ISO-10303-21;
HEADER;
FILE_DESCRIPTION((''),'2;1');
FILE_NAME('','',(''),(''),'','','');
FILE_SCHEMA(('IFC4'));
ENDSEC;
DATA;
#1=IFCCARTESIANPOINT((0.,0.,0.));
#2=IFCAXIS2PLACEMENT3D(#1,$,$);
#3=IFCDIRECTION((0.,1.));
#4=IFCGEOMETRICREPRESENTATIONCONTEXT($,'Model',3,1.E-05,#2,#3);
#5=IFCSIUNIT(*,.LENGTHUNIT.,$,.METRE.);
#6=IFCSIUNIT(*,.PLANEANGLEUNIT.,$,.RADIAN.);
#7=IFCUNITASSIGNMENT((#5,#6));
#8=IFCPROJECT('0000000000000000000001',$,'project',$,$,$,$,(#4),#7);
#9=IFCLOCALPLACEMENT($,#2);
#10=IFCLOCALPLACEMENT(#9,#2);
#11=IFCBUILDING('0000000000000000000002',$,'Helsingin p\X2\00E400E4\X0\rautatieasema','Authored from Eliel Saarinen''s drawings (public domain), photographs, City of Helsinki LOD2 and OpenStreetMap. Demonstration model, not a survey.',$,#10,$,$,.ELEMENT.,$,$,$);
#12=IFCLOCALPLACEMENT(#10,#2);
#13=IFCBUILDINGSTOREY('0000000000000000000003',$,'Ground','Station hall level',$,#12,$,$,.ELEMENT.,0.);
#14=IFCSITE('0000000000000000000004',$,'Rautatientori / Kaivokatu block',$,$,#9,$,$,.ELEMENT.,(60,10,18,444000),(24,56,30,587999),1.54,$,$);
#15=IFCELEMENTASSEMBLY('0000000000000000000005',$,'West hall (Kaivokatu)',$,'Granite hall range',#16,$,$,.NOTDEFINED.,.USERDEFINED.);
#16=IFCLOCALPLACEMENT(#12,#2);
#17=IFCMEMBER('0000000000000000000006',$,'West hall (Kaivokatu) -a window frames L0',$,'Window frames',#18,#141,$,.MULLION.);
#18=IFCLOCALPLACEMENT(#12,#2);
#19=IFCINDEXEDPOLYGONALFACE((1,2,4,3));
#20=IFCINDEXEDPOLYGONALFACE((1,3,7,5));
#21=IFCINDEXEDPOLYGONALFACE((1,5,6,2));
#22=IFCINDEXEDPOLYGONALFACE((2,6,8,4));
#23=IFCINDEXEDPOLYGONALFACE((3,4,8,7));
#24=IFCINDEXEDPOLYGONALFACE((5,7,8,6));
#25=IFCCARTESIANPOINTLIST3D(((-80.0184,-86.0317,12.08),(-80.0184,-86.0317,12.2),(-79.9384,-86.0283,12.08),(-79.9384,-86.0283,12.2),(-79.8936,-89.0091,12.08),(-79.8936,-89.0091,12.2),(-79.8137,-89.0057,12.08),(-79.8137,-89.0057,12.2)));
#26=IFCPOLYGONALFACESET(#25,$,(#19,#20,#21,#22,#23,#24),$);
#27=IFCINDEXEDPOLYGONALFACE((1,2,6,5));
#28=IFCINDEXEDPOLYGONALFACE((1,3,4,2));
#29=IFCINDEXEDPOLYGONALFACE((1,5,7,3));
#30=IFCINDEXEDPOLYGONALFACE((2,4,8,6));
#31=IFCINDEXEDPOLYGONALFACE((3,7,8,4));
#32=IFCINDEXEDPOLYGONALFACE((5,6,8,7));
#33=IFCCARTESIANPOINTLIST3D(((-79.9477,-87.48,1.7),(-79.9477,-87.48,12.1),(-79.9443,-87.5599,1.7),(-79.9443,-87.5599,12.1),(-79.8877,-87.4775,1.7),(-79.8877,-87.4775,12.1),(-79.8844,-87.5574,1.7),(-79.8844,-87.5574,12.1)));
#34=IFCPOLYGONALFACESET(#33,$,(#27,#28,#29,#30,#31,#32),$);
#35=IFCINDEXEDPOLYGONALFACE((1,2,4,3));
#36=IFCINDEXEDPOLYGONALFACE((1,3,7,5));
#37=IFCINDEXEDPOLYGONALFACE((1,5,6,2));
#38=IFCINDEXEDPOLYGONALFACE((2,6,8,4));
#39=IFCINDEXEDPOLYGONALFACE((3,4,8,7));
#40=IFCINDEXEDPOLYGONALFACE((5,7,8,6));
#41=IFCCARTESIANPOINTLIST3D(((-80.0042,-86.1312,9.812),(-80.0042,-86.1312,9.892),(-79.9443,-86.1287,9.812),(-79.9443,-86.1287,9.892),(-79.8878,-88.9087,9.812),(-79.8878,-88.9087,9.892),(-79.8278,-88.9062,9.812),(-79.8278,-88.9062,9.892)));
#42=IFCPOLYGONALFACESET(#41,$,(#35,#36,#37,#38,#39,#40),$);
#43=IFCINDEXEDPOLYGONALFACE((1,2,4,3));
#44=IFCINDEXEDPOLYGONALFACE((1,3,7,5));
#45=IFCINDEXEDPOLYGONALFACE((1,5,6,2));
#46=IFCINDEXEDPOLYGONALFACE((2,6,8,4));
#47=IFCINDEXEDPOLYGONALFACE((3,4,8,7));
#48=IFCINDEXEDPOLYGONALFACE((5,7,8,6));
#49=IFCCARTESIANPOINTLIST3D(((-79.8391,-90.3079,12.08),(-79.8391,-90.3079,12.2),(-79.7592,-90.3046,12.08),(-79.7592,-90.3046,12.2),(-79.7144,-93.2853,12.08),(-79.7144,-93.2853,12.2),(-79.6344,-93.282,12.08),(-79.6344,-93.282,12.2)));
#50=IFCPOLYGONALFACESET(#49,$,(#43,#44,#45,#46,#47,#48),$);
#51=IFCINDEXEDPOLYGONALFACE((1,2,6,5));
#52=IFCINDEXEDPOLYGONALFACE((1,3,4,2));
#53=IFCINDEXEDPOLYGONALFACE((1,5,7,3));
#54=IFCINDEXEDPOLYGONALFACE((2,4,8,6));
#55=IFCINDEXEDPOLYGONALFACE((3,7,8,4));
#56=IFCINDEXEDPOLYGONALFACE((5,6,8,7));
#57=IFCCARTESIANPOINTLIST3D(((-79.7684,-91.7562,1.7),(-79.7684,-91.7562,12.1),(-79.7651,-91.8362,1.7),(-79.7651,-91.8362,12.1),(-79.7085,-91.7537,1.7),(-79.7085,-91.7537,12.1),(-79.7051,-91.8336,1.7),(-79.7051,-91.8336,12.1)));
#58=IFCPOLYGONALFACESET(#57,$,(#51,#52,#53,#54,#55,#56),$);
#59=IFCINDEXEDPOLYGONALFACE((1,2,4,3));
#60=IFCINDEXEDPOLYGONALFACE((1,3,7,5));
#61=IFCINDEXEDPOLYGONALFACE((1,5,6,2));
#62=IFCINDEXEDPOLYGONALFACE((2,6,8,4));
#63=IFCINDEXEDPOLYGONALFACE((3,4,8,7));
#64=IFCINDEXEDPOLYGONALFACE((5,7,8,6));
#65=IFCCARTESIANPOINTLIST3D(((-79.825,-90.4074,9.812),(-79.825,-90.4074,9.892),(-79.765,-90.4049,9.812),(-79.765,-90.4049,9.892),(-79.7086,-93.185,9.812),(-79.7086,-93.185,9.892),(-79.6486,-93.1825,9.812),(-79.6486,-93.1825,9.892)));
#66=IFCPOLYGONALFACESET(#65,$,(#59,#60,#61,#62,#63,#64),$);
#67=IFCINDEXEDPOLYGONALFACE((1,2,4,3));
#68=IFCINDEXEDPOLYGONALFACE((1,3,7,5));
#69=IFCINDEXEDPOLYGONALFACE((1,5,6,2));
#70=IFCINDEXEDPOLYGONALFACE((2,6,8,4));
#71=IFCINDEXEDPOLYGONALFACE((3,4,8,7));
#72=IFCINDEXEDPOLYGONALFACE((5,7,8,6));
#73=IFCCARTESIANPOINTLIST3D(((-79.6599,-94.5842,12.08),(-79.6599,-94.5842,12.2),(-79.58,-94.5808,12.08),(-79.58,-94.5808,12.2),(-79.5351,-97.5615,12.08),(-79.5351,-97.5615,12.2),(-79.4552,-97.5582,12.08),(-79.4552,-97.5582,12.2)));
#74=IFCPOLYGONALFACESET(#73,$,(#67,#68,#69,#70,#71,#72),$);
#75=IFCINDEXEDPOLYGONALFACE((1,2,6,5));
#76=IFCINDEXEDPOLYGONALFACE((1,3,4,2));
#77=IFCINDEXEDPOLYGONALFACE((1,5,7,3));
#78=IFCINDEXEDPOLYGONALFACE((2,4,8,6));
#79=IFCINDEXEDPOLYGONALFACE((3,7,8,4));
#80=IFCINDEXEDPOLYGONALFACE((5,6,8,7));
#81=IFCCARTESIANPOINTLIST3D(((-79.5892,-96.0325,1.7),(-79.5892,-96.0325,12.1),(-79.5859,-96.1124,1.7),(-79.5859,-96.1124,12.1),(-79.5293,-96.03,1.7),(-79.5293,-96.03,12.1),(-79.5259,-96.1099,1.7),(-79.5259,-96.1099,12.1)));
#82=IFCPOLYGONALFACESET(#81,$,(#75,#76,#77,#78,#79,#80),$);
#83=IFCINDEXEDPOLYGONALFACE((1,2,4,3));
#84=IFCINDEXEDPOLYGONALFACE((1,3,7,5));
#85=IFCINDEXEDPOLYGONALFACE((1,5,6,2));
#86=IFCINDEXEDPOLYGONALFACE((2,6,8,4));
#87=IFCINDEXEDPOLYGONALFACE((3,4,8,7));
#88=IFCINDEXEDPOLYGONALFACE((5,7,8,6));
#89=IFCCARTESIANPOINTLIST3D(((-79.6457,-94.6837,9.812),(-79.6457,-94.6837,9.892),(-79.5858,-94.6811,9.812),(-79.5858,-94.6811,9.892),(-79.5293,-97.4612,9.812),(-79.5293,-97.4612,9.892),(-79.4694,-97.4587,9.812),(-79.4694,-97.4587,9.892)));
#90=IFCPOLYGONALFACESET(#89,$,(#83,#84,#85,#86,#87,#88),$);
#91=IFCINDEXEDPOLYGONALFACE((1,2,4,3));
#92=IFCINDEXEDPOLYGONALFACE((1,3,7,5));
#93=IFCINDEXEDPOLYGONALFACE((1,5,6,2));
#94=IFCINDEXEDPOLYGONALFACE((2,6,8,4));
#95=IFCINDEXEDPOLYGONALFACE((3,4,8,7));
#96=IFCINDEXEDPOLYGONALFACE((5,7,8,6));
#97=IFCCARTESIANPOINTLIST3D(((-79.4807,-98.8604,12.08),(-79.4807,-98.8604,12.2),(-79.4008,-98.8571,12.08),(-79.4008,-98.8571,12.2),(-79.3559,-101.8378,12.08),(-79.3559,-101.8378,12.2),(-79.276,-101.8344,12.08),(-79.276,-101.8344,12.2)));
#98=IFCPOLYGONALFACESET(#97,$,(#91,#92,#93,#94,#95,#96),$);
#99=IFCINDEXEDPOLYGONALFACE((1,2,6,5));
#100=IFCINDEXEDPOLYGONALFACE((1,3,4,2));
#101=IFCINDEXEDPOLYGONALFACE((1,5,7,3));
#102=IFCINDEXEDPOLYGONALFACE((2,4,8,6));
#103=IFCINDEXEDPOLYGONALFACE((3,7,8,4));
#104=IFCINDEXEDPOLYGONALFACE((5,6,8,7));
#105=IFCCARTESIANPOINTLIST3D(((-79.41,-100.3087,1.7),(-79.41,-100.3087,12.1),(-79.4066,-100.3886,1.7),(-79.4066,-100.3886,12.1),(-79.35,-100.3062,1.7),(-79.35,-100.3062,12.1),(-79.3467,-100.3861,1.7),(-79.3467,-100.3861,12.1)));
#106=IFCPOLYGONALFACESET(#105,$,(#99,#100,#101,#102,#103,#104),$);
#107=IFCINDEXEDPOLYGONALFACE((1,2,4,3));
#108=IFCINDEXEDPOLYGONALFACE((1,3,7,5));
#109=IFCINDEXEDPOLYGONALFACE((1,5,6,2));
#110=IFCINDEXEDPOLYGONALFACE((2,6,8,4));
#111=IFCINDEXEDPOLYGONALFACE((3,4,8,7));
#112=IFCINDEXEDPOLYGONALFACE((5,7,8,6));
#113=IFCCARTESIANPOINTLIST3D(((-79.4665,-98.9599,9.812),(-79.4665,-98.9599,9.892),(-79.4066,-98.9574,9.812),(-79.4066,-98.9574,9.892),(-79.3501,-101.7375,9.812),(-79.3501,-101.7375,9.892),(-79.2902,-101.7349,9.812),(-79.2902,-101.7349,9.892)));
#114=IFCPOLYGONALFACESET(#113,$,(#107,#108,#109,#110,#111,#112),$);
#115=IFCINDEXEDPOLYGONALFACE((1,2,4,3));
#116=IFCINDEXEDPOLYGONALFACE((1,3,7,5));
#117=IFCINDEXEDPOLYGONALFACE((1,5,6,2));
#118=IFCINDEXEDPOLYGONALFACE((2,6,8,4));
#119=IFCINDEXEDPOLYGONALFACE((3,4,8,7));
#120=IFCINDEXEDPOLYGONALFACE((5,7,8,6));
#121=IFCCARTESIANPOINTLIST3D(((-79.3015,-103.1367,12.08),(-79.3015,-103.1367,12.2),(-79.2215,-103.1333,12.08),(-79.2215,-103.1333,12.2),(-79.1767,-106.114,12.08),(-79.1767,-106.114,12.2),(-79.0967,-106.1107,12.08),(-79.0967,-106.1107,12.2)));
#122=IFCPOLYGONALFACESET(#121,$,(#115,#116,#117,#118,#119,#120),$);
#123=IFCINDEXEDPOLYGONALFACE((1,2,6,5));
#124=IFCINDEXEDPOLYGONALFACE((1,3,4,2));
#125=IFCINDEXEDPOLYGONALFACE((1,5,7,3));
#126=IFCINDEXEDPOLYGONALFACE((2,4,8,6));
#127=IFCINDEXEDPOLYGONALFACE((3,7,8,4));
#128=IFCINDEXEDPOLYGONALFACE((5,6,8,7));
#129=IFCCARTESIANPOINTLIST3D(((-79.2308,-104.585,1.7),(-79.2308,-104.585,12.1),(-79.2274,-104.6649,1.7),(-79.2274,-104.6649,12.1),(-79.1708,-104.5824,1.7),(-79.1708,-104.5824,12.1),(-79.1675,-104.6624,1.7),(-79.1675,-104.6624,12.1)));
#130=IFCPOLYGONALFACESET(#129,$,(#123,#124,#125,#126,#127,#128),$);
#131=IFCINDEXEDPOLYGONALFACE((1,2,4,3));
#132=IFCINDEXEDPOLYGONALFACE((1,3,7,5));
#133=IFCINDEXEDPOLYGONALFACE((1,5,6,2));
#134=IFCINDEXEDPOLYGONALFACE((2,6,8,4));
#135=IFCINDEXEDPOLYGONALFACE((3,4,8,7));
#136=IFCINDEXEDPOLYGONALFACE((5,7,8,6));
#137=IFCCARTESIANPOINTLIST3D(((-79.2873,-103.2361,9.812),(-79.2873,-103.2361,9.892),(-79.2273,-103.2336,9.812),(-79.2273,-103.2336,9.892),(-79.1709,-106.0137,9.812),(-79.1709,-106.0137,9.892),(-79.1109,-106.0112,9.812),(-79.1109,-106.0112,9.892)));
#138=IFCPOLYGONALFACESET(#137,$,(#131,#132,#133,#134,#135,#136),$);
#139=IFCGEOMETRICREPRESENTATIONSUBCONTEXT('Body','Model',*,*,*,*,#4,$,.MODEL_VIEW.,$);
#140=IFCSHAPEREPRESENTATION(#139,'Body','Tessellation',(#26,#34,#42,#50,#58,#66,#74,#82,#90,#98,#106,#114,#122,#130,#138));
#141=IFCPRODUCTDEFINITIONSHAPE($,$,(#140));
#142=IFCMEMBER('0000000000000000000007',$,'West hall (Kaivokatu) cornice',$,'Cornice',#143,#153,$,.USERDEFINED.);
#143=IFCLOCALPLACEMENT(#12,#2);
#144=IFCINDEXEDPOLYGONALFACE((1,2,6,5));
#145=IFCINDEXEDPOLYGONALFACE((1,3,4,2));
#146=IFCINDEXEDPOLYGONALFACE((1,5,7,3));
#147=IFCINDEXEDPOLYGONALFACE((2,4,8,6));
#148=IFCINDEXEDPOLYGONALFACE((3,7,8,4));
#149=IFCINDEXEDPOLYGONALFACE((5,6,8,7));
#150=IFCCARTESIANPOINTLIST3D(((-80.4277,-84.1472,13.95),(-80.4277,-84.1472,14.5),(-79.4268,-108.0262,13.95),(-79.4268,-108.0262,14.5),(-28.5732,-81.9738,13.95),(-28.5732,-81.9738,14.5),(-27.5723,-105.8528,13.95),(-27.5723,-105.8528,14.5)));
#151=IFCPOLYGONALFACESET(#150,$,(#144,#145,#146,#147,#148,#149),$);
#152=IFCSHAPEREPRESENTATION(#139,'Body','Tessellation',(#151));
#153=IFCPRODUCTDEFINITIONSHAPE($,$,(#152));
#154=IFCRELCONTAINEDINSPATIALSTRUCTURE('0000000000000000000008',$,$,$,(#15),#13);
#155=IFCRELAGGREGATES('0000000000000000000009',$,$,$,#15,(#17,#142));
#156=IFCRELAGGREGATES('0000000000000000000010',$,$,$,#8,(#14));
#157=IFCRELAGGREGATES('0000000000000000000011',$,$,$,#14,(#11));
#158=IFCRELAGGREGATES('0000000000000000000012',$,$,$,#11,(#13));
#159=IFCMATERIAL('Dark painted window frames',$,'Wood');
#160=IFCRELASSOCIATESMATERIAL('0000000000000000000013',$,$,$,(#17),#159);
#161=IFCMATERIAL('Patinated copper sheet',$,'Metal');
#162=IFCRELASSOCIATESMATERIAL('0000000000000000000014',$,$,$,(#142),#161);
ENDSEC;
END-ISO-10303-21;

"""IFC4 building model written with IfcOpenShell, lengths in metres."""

from ifc_helpers import new_model, si_unit, direction, frame, frame_2d, origin, place, context, subcontext, project, spatial, rectangle, extrude, material, element, aggregate, save


model = new_model("IFC4")

# Units and contexts
model_context = context("Model", 3, precision=1e-05, world=origin(), true_north=direction((0.0, 1.0)))
body_context = subcontext(model_context, "Body", "Model", "MODEL_VIEW")
ifc_project = project(units=[si_unit("LENGTHUNIT", "METRE"), si_unit("PLANEANGLEUNIT", "RADIAN")], contexts=[model_context])

# Site, building, storey
site_placement = place(None, origin())
site = spatial("IfcSite", under=ifc_project, at=site_placement, Name="Rautatientori / Kaivokatu block", CompositionType="ELEMENT", RefLatitude=(60, 10, 18, 444000), RefLongitude=(24, 56, 30, 587999), RefElevation=1.54)
building_placement = place(site_placement, origin())
building = spatial("IfcBuilding", under=site, at=building_placement, Name="Helsingin päärautatieasema", Description="Authored from Eliel Saarinen's drawings (public domain), photographs, City of Helsinki LOD2 and OpenStreetMap. Demonstration model, not a survey.", CompositionType="ELEMENT")
storey_placement = place(building_placement, origin())
storey = spatial("IfcBuildingStorey", under=building, at=storey_placement, Name="Ground", Description="Station hall level", CompositionType="ELEMENT", Elevation=0.0)

# Element assembly
assembly_1_placement = place(building_placement, origin())
assembly_1 = element("IfcElementAssembly", 1, at=assembly_1_placement, inside=storey, Name="West hall (Kaivokatu)", ObjectType="Granite hall range", AssemblyPlace="NOTDEFINED", PredefinedType="USERDEFINED")

# Members
ifc_material_1 = material(Name="Dark painted window frames", Category="Wood")
member_1_placement = place(building_placement, origin())
member_1 = element("IfcMember", 2, at=member_1_placement, material=ifc_material_1, Name="West hall (Kaivokatu) -a window frames L0", ObjectType="Window frames", PredefinedType="MULLION", context=body_context, shape_type="SweptSolid", body=[
    extrude(rectangle(XDim=2.98, YDim=0.08, at=frame_2d((0.0, 0.0), x_axis=(0.041876, -0.999123))), frame((-79.916, -87.5187, 12.08)), (0.0, 0.0, 1.0), 0.12),
    extrude(rectangle(XDim=0.08, YDim=0.06, at=frame_2d((0.0, 0.0), x_axis=(0.041876, -0.999123))), frame((-79.916, -87.5187, 1.7)), (0.0, 0.0, 1.0), 10.4),
    extrude(rectangle(XDim=2.78, YDim=0.06, at=frame_2d((0.0, 0.0), x_axis=(0.041876, -0.999123))), frame((-79.916, -87.5187, 9.812)), (0.0, 0.0, 1.0), 0.08),
    extrude(rectangle(XDim=2.98, YDim=0.08, at=frame_2d((0.0, 0.0), x_axis=(0.041876, -0.999123))), frame((-79.7368, -91.7949, 12.08)), (0.0, 0.0, 1.0), 0.12),
    extrude(rectangle(XDim=0.08, YDim=0.06, at=frame_2d((0.0, 0.0), x_axis=(0.041876, -0.999123))), frame((-79.7368, -91.7949, 1.7)), (0.0, 0.0, 1.0), 10.4),
    extrude(rectangle(XDim=2.78, YDim=0.06, at=frame_2d((0.0, 0.0), x_axis=(0.041876, -0.999123))), frame((-79.7368, -91.7949, 9.812)), (0.0, 0.0, 1.0), 0.08),
    extrude(rectangle(XDim=2.98, YDim=0.08, at=frame_2d((0.0, 0.0), x_axis=(0.041876, -0.999123))), frame((-79.5576, -96.0712, 12.08)), (0.0, 0.0, 1.0), 0.12),
    extrude(rectangle(XDim=0.08, YDim=0.06, at=frame_2d((0.0, 0.0), x_axis=(0.041876, -0.999123))), frame((-79.5576, -96.0712, 1.7)), (0.0, 0.0, 1.0), 10.4),
    extrude(rectangle(XDim=2.78, YDim=0.06, at=frame_2d((0.0, 0.0), x_axis=(0.041876, -0.999123))), frame((-79.5576, -96.0712, 9.812)), (0.0, 0.0, 1.0), 0.08),
    extrude(rectangle(XDim=2.98, YDim=0.08, at=frame_2d((0.0, 0.0), x_axis=(0.041876, -0.999123))), frame((-79.3783, -100.3474, 12.08)), (0.0, 0.0, 1.0), 0.12),
    extrude(rectangle(XDim=0.08, YDim=0.06, at=frame_2d((0.0, 0.0), x_axis=(0.041876, -0.999123))), frame((-79.3783, -100.3474, 1.7)), (0.0, 0.0, 1.0), 10.4),
    extrude(rectangle(XDim=2.78, YDim=0.06, at=frame_2d((0.0, 0.0), x_axis=(0.041876, -0.999123))), frame((-79.3783, -100.3474, 9.812)), (0.0, 0.0, 1.0), 0.08),
    extrude(rectangle(XDim=2.98, YDim=0.08, at=frame_2d((0.0, 0.0), x_axis=(0.041876, -0.999123))), frame((-79.1991, -104.6237, 12.08)), (0.0, 0.0, 1.0), 0.12),
    extrude(rectangle(XDim=0.08, YDim=0.06, at=frame_2d((0.0, 0.0), x_axis=(0.041876, -0.999123))), frame((-79.1991, -104.6237, 1.7)), (0.0, 0.0, 1.0), 10.4),
    extrude(rectangle(XDim=2.78, YDim=0.06, at=frame_2d((0.0, 0.0), x_axis=(0.041876, -0.999123))), frame((-79.1991, -104.6237, 9.812)), (0.0, 0.0, 1.0), 0.08),
])
ifc_material_2 = material(Name="Patinated copper sheet", Category="Metal")
member_2_placement = place(building_placement, origin())
member_2 = element("IfcMember", 3, at=member_2_placement, material=ifc_material_2, Name="West hall (Kaivokatu) cornice", ObjectType="Cornice", PredefinedType="USERDEFINED", context=body_context, shape_type="SweptSolid", body=[
    extrude(rectangle(XDim=51.9, YDim=23.9, at=frame_2d((0.0, 0.0), x_axis=(0.999123, 0.041876))), frame((-54.0, -95.0, 13.95)), (0.0, 0.0, 1.0), 0.55),
])

aggregate(assembly_1, [member_1, member_2])

save(model, "model.ifc")
